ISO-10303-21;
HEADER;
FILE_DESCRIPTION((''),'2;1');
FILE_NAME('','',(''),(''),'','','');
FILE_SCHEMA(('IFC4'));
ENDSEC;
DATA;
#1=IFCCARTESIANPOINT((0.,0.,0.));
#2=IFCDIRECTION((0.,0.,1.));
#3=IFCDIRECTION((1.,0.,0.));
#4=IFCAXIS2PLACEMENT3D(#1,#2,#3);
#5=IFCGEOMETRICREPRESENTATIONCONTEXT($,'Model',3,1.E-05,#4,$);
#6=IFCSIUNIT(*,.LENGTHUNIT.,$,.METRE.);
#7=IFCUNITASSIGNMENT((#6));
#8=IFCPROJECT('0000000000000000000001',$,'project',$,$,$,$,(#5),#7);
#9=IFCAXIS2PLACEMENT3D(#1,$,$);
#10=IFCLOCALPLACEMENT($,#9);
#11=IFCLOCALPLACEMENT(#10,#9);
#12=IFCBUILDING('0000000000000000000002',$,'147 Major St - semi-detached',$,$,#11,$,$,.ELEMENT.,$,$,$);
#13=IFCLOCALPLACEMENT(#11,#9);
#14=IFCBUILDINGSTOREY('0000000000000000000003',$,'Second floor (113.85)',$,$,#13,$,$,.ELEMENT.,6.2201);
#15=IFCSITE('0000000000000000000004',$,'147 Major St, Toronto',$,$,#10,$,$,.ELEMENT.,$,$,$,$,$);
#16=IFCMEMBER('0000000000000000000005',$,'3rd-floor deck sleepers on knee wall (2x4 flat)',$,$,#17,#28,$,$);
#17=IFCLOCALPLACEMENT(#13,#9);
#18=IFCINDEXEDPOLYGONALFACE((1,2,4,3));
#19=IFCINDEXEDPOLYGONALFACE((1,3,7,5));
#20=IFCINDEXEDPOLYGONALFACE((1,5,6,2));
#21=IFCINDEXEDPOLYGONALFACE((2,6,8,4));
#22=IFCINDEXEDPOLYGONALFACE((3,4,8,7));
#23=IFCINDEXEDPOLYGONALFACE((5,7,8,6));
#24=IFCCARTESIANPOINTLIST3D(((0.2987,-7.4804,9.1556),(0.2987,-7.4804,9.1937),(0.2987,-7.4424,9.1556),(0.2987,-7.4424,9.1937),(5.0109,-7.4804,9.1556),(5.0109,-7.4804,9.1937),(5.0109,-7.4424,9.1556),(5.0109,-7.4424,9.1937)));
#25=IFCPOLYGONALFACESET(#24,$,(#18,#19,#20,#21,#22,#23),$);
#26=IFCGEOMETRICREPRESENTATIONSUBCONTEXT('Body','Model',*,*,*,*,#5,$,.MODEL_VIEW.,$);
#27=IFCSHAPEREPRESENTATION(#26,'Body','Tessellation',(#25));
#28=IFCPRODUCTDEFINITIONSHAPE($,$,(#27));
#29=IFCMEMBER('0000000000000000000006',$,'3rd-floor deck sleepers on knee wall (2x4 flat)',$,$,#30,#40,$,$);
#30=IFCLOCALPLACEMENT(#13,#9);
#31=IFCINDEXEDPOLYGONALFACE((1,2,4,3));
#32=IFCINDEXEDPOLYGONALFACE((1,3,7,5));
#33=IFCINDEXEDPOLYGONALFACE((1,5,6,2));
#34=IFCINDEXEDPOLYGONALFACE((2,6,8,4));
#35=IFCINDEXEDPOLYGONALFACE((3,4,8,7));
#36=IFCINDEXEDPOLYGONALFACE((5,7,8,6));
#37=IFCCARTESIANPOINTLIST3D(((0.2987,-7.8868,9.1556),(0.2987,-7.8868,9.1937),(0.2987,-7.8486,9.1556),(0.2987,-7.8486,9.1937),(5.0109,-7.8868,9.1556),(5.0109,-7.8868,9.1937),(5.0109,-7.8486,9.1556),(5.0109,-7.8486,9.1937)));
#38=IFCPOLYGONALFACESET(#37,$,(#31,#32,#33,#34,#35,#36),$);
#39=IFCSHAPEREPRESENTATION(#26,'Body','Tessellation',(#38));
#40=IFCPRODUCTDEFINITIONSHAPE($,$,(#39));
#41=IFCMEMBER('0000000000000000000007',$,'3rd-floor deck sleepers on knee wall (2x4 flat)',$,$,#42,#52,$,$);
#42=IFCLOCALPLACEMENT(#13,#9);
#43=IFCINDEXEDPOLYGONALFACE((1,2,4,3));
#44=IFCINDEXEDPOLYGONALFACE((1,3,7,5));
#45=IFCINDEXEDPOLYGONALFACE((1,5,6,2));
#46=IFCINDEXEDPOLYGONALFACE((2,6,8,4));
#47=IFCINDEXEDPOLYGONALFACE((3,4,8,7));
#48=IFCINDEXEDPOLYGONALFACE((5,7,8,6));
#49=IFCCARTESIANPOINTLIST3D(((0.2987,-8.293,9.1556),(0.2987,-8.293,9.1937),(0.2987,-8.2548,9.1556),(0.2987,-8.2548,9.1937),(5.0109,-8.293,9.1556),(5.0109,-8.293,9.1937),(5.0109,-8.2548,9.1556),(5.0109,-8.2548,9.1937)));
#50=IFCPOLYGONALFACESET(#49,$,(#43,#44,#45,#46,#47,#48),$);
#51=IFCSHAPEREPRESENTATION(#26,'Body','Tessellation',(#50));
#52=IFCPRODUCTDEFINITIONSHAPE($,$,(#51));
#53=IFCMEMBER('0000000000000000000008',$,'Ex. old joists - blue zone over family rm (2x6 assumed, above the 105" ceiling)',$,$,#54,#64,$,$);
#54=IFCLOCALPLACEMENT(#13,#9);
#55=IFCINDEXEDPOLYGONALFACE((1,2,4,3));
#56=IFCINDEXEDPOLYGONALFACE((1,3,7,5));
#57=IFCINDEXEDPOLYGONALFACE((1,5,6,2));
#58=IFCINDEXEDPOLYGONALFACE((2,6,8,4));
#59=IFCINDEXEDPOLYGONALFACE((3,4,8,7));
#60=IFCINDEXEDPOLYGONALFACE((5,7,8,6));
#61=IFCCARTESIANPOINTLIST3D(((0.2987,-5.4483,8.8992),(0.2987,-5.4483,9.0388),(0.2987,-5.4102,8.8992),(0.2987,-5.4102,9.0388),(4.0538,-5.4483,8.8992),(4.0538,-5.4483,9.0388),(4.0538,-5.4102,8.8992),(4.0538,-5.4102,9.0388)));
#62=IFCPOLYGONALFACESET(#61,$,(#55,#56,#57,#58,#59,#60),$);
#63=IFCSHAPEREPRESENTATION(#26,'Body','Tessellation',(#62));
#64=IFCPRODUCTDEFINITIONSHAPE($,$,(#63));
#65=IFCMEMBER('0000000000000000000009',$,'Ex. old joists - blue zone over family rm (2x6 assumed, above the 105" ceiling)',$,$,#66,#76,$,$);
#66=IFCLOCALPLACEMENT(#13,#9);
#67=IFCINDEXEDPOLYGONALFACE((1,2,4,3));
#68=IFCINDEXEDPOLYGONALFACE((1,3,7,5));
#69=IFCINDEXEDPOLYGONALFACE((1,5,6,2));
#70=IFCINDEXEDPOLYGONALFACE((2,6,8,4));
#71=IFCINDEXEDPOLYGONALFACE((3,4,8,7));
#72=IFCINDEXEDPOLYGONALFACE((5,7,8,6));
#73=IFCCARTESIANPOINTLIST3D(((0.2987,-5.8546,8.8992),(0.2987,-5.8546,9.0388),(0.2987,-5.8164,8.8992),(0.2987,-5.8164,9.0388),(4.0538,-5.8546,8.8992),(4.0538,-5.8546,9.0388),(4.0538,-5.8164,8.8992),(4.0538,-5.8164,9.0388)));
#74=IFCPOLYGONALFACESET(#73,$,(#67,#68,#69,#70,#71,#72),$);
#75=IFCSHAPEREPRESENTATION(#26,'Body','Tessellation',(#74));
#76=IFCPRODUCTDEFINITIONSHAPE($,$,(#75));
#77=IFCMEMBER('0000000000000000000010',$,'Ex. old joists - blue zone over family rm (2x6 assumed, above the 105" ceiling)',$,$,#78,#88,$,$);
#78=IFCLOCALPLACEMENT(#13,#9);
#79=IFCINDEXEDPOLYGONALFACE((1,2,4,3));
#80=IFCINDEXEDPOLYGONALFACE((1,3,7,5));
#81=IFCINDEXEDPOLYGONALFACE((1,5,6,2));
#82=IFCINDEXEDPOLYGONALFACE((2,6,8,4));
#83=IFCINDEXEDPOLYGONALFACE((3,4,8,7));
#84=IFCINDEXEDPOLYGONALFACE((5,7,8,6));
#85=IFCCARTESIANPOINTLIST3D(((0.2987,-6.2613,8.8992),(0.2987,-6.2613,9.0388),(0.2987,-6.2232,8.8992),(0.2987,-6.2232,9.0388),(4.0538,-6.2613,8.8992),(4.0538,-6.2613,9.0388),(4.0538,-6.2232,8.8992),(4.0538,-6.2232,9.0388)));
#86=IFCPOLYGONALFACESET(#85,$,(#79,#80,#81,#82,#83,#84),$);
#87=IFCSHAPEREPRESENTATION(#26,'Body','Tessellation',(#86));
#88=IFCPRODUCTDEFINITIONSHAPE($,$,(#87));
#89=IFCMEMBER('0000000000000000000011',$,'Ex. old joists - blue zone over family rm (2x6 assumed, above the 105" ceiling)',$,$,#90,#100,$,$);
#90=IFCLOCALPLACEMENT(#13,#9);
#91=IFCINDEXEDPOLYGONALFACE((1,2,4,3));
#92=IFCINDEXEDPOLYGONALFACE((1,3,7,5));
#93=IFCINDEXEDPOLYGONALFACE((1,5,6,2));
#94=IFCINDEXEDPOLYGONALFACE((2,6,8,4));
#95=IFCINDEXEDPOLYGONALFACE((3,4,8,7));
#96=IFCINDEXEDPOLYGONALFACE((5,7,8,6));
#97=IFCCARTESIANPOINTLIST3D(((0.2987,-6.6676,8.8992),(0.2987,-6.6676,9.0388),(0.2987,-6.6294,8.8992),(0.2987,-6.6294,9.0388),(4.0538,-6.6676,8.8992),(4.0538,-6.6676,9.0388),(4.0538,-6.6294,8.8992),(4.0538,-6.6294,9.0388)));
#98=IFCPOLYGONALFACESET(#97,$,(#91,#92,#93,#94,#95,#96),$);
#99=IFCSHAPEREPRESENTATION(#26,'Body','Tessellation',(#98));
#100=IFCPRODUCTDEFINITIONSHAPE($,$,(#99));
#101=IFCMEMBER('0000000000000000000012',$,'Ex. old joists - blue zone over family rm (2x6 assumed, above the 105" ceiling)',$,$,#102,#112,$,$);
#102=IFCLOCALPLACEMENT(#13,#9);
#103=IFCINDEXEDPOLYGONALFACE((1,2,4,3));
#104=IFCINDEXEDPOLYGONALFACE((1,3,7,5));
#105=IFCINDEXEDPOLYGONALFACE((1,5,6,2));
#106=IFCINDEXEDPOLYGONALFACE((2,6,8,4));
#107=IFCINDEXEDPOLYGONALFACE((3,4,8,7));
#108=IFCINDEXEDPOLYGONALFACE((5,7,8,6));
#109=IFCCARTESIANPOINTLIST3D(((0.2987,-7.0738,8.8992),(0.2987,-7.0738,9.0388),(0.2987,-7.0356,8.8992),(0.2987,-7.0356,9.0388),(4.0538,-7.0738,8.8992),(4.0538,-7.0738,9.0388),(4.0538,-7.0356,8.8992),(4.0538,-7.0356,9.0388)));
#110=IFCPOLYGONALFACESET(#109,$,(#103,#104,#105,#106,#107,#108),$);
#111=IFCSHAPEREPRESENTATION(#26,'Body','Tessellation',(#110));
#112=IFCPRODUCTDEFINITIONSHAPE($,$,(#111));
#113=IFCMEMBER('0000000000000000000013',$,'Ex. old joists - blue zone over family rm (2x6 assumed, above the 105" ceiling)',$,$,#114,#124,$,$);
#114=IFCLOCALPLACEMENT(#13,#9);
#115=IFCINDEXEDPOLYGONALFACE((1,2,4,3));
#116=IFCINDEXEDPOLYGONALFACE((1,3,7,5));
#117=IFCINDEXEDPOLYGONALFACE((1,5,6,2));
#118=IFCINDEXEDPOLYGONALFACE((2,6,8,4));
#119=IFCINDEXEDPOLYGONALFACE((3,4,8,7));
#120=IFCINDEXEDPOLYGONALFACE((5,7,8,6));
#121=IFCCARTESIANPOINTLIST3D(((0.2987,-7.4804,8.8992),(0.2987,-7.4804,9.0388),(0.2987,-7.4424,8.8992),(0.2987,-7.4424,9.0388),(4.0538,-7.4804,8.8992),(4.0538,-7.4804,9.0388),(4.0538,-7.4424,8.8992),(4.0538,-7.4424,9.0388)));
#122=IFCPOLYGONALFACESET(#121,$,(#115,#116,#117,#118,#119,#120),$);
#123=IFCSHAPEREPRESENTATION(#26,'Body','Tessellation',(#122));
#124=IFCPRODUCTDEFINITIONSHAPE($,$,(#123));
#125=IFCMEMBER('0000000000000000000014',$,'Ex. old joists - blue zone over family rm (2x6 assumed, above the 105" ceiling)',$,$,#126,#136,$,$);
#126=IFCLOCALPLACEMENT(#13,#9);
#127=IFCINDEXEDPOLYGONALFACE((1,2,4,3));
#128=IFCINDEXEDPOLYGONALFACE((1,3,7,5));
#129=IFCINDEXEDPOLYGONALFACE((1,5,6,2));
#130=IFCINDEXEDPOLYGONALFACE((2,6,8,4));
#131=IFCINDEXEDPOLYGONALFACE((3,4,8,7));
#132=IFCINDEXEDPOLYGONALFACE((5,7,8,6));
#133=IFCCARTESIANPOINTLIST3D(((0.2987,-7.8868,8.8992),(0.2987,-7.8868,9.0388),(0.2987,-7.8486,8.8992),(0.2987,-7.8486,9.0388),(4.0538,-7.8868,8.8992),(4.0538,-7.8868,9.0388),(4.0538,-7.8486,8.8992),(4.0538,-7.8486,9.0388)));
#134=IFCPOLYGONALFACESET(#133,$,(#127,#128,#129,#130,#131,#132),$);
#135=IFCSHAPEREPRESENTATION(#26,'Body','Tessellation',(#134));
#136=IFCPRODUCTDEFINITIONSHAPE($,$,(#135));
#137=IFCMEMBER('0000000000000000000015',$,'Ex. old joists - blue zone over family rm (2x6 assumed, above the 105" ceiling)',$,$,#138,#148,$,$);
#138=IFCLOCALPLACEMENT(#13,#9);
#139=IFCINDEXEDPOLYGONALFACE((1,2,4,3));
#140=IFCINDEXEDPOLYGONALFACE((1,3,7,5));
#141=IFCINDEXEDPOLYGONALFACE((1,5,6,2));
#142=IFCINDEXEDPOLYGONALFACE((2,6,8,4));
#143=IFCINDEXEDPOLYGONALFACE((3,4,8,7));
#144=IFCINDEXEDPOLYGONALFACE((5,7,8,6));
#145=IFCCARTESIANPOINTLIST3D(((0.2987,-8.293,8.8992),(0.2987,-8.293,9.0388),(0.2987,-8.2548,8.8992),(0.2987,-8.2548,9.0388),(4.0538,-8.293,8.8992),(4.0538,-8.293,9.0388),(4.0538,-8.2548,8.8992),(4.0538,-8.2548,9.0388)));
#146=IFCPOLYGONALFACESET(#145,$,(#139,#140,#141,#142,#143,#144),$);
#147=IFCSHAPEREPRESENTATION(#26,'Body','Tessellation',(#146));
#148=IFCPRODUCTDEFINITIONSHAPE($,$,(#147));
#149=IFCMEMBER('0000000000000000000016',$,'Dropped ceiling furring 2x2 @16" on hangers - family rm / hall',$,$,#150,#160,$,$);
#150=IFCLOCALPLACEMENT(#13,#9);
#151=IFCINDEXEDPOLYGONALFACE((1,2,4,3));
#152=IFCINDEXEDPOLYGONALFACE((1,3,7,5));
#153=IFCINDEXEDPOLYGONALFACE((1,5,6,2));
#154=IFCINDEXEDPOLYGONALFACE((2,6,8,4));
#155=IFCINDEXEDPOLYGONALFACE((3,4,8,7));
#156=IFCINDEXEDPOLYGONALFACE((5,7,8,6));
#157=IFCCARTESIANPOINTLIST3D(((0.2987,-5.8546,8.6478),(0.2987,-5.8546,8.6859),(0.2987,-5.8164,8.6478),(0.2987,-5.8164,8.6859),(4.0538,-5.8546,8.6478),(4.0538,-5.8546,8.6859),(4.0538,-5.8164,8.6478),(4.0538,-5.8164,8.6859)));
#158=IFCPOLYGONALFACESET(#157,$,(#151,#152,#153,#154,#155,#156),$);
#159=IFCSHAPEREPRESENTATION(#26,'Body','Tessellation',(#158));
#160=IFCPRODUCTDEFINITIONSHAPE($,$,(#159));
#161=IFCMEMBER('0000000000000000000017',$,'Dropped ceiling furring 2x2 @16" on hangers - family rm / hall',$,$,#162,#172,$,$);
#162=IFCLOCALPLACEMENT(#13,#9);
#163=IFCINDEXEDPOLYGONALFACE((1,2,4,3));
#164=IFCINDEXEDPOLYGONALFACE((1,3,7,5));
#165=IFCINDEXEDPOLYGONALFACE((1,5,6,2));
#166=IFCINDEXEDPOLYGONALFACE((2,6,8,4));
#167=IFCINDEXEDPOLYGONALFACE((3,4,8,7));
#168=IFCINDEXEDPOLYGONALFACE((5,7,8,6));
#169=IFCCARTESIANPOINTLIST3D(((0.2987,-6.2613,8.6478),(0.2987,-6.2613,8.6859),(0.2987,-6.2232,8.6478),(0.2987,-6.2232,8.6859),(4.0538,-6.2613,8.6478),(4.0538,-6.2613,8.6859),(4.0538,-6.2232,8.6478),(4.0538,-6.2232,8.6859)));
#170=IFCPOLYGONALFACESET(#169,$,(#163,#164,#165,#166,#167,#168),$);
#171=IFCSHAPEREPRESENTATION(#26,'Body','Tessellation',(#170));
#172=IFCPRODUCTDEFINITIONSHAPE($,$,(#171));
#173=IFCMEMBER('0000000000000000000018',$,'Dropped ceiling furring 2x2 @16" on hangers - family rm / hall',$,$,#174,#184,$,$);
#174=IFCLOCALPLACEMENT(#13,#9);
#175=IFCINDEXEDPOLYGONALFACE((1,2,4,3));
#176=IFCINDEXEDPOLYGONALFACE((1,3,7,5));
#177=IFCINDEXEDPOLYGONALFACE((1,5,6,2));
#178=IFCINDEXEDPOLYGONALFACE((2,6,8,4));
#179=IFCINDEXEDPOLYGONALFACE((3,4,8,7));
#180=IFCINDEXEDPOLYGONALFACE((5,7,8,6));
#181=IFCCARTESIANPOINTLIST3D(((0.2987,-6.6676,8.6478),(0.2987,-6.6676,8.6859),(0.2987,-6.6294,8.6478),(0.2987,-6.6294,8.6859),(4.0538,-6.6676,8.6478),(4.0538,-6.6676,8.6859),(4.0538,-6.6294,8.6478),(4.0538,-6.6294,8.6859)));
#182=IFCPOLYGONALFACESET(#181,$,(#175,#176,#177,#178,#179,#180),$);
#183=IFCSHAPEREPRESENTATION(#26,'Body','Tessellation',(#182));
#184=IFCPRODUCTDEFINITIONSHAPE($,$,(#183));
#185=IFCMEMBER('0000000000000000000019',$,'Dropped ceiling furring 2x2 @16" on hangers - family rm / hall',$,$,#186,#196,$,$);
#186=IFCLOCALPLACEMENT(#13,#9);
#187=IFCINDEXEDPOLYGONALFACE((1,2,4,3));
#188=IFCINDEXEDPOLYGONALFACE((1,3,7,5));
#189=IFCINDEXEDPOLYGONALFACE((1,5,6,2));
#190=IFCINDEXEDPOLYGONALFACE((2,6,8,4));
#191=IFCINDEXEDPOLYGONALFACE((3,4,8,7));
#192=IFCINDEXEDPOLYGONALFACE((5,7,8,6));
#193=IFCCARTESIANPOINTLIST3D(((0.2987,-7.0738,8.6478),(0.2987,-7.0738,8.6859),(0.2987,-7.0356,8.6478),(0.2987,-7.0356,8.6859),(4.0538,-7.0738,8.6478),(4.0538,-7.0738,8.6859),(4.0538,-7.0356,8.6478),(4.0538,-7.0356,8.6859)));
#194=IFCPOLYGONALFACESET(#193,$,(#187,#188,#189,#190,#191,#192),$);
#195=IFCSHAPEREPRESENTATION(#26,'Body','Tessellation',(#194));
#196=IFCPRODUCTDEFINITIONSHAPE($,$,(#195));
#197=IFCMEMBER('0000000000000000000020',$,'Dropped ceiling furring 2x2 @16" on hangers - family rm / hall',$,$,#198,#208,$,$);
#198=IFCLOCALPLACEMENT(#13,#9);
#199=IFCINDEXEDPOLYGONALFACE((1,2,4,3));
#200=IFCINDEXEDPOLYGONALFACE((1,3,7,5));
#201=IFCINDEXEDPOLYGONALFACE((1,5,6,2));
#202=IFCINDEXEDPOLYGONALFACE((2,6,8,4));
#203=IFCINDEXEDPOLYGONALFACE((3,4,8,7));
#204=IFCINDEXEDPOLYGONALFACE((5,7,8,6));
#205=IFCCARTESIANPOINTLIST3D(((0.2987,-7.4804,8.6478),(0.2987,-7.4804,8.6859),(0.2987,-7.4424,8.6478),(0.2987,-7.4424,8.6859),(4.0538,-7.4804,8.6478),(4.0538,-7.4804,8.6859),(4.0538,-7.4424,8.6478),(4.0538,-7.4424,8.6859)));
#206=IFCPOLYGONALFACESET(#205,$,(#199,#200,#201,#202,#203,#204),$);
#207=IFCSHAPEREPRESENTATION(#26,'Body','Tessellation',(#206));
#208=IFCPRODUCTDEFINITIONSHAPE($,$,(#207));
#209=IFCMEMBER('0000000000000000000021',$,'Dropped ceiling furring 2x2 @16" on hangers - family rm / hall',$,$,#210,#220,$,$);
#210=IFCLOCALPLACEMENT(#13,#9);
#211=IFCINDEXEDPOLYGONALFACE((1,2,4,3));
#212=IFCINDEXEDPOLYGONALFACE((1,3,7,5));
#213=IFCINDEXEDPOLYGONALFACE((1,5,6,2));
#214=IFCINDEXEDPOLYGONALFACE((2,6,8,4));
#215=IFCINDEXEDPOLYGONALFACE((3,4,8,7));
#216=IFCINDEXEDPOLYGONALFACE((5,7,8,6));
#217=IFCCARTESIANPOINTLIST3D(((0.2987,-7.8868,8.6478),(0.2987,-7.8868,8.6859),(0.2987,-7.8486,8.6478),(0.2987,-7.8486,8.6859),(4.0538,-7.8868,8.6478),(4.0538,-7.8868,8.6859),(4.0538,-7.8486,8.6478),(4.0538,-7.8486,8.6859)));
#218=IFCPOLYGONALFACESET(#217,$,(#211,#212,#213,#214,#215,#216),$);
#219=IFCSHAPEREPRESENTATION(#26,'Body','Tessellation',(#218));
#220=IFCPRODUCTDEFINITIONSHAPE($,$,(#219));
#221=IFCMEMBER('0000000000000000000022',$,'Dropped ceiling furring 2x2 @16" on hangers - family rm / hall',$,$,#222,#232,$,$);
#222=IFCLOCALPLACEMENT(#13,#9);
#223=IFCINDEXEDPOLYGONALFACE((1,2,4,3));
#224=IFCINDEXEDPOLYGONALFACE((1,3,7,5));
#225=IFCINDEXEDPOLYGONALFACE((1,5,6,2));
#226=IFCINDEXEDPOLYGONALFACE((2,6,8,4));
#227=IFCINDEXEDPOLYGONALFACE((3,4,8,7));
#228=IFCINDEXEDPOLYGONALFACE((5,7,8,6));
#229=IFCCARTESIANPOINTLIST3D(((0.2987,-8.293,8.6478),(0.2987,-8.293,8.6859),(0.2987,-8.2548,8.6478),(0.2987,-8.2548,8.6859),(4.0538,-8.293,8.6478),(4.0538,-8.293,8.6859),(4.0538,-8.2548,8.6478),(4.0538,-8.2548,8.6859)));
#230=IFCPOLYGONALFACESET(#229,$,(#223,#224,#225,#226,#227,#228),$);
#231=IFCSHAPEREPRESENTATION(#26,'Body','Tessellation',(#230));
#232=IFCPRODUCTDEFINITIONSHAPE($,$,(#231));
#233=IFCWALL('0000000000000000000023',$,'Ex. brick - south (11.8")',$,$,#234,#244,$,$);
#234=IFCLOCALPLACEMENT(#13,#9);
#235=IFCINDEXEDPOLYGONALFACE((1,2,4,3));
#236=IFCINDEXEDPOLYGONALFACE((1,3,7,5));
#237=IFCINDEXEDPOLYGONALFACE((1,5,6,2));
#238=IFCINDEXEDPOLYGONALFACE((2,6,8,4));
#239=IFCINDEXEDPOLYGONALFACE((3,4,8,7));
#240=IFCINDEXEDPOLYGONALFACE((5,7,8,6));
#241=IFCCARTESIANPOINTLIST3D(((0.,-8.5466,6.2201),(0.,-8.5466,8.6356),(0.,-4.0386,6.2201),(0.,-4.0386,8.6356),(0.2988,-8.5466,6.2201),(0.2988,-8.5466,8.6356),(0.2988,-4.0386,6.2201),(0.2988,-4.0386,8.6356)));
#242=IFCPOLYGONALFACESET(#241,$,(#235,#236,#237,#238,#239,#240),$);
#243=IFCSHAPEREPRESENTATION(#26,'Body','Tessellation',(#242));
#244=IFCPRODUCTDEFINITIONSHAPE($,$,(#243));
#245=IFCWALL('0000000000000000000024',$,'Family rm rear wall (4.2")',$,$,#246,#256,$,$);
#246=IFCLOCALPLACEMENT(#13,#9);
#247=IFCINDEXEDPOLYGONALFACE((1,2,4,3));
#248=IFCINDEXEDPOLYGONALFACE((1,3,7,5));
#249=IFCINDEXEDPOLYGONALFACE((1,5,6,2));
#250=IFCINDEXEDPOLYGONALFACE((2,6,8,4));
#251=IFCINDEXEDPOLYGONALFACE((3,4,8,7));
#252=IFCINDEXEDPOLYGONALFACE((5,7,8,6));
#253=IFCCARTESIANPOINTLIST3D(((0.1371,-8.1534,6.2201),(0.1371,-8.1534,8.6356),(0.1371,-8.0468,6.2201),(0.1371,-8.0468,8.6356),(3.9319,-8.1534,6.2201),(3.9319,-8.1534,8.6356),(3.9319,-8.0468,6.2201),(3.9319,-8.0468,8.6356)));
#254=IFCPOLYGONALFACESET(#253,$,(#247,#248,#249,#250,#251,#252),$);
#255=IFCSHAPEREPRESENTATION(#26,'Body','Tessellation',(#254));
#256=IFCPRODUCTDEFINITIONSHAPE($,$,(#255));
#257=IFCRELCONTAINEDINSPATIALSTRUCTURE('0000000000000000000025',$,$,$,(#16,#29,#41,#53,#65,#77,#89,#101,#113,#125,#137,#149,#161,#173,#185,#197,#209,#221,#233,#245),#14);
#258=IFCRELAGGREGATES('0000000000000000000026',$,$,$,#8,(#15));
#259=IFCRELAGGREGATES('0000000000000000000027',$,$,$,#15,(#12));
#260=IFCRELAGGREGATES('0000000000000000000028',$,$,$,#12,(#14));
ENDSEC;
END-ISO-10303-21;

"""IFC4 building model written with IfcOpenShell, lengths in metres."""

from ifc_helpers import new_model, si_unit, frame, origin, origin_with_axes, place, context, subcontext, project, spatial, rectangle, extrude, element, save


model = new_model("IFC4")

# Units and contexts
model_context = context("Model", 3, precision=1e-05, world=origin_with_axes())
body_context = subcontext(model_context, "Body", "Model", "MODEL_VIEW")
ifc_project = project(units=[si_unit("LENGTHUNIT", "METRE")], contexts=[model_context])

# Site, building, storey
site_placement = place(None, origin())
site = spatial("IfcSite", under=ifc_project, at=site_placement, Name="147 Major St, Toronto", CompositionType="ELEMENT")
building_placement = place(site_placement, origin())
building = spatial("IfcBuilding", under=site, at=building_placement, Name="147 Major St - semi-detached", CompositionType="ELEMENT")
storey_placement = place(building_placement, origin())
storey = spatial("IfcBuildingStorey", under=building, at=storey_placement, Name="Second floor (113.85)", CompositionType="ELEMENT", Elevation=6.2201)

# Members
for number, where, name in (
    (1, (2.6548, -7.4614, 9.1556), "3rd-floor deck sleepers on knee wall (2x4 flat)"),
    (2, (2.6548, -7.8677, 9.1556), "3rd-floor deck sleepers on knee wall (2x4 flat)"),
    (3, (2.6548, -8.2739, 9.1556), "3rd-floor deck sleepers on knee wall (2x4 flat)"),
):
    element("IfcMember", number, at=place(storey_placement, frame(where)), inside=storey, Name=name, context=body_context, shape_type="SweptSolid", body=[
        extrude(rectangle(XDim=4.7122, YDim=0.0381), origin_with_axes(), (0.0, 0.0, 1.0), 0.0381),
    ])
for number, where, name in (
    (4, (2.1763, -5.4293, 8.8992), "Ex. old joists - blue zone over family rm (2x6 assumed, above the 105\" ceiling)"),
    (5, (2.1763, -5.8355, 8.8992), "Ex. old joists - blue zone over family rm (2x6 assumed, above the 105\" ceiling)"),
    (6, (2.1763, -6.2422, 8.8992), "Ex. old joists - blue zone over family rm (2x6 assumed, above the 105\" ceiling)"),
    (7, (2.1763, -6.6485, 8.8992), "Ex. old joists - blue zone over family rm (2x6 assumed, above the 105\" ceiling)"),
    (8, (2.1763, -7.0547, 8.8992), "Ex. old joists - blue zone over family rm (2x6 assumed, above the 105\" ceiling)"),
    (9, (2.1763, -7.4614, 8.8992), "Ex. old joists - blue zone over family rm (2x6 assumed, above the 105\" ceiling)"),
    (10, (2.1763, -7.8677, 8.8992), "Ex. old joists - blue zone over family rm (2x6 assumed, above the 105\" ceiling)"),
    (11, (2.1763, -8.2739, 8.8992), "Ex. old joists - blue zone over family rm (2x6 assumed, above the 105\" ceiling)"),
):
    element("IfcMember", number, at=place(storey_placement, frame(where)), inside=storey, Name=name, context=body_context, shape_type="SweptSolid", body=[
        extrude(rectangle(XDim=3.7551, YDim=0.0381), origin_with_axes(), (0.0, 0.0, 1.0), 0.1396),
    ])
for number, where, name in (
    (12, (2.1763, -5.8355, 8.6478), "Dropped ceiling furring 2x2 @16\" on hangers - family rm / hall"),
    (13, (2.1763, -6.2422, 8.6478), "Dropped ceiling furring 2x2 @16\" on hangers - family rm / hall"),
    (14, (2.1763, -6.6485, 8.6478), "Dropped ceiling furring 2x2 @16\" on hangers - family rm / hall"),
    (15, (2.1763, -7.0547, 8.6478), "Dropped ceiling furring 2x2 @16\" on hangers - family rm / hall"),
    (16, (2.1763, -7.4614, 8.6478), "Dropped ceiling furring 2x2 @16\" on hangers - family rm / hall"),
    (17, (2.1763, -7.8677, 8.6478), "Dropped ceiling furring 2x2 @16\" on hangers - family rm / hall"),
    (18, (2.1763, -8.2739, 8.6478), "Dropped ceiling furring 2x2 @16\" on hangers - family rm / hall"),
):
    element("IfcMember", number, at=place(storey_placement, frame(where)), inside=storey, Name=name, context=body_context, shape_type="SweptSolid", body=[
        extrude(rectangle(XDim=3.7551, YDim=0.0381), origin_with_axes(), (0.0, 0.0, 1.0), 0.0381),
    ])

# Walls
wall_1_placement = place(storey_placement, frame((0.1494, -6.2926, 6.2201)))
element("IfcWall", 19, at=wall_1_placement, inside=storey, Name="Ex. brick - south (11.8\")", context=body_context, shape_type="SweptSolid", body=[
    extrude(rectangle(XDim=0.2987, YDim=4.508), origin_with_axes(), (0.0, 0.0, 1.0), 2.4155),
])
wall_2_placement = place(storey_placement, frame((2.0345, -8.1001, 6.2201)))
element("IfcWall", 20, at=wall_2_placement, inside=storey, Name="Family rm rear wall (4.2\")", context=body_context, shape_type="SweptSolid", body=[
    extrude(rectangle(XDim=3.7948, YDim=0.1067), origin_with_axes(), (0.0, 0.0, 1.0), 2.4155),
])

save(model, "model.ifc")
